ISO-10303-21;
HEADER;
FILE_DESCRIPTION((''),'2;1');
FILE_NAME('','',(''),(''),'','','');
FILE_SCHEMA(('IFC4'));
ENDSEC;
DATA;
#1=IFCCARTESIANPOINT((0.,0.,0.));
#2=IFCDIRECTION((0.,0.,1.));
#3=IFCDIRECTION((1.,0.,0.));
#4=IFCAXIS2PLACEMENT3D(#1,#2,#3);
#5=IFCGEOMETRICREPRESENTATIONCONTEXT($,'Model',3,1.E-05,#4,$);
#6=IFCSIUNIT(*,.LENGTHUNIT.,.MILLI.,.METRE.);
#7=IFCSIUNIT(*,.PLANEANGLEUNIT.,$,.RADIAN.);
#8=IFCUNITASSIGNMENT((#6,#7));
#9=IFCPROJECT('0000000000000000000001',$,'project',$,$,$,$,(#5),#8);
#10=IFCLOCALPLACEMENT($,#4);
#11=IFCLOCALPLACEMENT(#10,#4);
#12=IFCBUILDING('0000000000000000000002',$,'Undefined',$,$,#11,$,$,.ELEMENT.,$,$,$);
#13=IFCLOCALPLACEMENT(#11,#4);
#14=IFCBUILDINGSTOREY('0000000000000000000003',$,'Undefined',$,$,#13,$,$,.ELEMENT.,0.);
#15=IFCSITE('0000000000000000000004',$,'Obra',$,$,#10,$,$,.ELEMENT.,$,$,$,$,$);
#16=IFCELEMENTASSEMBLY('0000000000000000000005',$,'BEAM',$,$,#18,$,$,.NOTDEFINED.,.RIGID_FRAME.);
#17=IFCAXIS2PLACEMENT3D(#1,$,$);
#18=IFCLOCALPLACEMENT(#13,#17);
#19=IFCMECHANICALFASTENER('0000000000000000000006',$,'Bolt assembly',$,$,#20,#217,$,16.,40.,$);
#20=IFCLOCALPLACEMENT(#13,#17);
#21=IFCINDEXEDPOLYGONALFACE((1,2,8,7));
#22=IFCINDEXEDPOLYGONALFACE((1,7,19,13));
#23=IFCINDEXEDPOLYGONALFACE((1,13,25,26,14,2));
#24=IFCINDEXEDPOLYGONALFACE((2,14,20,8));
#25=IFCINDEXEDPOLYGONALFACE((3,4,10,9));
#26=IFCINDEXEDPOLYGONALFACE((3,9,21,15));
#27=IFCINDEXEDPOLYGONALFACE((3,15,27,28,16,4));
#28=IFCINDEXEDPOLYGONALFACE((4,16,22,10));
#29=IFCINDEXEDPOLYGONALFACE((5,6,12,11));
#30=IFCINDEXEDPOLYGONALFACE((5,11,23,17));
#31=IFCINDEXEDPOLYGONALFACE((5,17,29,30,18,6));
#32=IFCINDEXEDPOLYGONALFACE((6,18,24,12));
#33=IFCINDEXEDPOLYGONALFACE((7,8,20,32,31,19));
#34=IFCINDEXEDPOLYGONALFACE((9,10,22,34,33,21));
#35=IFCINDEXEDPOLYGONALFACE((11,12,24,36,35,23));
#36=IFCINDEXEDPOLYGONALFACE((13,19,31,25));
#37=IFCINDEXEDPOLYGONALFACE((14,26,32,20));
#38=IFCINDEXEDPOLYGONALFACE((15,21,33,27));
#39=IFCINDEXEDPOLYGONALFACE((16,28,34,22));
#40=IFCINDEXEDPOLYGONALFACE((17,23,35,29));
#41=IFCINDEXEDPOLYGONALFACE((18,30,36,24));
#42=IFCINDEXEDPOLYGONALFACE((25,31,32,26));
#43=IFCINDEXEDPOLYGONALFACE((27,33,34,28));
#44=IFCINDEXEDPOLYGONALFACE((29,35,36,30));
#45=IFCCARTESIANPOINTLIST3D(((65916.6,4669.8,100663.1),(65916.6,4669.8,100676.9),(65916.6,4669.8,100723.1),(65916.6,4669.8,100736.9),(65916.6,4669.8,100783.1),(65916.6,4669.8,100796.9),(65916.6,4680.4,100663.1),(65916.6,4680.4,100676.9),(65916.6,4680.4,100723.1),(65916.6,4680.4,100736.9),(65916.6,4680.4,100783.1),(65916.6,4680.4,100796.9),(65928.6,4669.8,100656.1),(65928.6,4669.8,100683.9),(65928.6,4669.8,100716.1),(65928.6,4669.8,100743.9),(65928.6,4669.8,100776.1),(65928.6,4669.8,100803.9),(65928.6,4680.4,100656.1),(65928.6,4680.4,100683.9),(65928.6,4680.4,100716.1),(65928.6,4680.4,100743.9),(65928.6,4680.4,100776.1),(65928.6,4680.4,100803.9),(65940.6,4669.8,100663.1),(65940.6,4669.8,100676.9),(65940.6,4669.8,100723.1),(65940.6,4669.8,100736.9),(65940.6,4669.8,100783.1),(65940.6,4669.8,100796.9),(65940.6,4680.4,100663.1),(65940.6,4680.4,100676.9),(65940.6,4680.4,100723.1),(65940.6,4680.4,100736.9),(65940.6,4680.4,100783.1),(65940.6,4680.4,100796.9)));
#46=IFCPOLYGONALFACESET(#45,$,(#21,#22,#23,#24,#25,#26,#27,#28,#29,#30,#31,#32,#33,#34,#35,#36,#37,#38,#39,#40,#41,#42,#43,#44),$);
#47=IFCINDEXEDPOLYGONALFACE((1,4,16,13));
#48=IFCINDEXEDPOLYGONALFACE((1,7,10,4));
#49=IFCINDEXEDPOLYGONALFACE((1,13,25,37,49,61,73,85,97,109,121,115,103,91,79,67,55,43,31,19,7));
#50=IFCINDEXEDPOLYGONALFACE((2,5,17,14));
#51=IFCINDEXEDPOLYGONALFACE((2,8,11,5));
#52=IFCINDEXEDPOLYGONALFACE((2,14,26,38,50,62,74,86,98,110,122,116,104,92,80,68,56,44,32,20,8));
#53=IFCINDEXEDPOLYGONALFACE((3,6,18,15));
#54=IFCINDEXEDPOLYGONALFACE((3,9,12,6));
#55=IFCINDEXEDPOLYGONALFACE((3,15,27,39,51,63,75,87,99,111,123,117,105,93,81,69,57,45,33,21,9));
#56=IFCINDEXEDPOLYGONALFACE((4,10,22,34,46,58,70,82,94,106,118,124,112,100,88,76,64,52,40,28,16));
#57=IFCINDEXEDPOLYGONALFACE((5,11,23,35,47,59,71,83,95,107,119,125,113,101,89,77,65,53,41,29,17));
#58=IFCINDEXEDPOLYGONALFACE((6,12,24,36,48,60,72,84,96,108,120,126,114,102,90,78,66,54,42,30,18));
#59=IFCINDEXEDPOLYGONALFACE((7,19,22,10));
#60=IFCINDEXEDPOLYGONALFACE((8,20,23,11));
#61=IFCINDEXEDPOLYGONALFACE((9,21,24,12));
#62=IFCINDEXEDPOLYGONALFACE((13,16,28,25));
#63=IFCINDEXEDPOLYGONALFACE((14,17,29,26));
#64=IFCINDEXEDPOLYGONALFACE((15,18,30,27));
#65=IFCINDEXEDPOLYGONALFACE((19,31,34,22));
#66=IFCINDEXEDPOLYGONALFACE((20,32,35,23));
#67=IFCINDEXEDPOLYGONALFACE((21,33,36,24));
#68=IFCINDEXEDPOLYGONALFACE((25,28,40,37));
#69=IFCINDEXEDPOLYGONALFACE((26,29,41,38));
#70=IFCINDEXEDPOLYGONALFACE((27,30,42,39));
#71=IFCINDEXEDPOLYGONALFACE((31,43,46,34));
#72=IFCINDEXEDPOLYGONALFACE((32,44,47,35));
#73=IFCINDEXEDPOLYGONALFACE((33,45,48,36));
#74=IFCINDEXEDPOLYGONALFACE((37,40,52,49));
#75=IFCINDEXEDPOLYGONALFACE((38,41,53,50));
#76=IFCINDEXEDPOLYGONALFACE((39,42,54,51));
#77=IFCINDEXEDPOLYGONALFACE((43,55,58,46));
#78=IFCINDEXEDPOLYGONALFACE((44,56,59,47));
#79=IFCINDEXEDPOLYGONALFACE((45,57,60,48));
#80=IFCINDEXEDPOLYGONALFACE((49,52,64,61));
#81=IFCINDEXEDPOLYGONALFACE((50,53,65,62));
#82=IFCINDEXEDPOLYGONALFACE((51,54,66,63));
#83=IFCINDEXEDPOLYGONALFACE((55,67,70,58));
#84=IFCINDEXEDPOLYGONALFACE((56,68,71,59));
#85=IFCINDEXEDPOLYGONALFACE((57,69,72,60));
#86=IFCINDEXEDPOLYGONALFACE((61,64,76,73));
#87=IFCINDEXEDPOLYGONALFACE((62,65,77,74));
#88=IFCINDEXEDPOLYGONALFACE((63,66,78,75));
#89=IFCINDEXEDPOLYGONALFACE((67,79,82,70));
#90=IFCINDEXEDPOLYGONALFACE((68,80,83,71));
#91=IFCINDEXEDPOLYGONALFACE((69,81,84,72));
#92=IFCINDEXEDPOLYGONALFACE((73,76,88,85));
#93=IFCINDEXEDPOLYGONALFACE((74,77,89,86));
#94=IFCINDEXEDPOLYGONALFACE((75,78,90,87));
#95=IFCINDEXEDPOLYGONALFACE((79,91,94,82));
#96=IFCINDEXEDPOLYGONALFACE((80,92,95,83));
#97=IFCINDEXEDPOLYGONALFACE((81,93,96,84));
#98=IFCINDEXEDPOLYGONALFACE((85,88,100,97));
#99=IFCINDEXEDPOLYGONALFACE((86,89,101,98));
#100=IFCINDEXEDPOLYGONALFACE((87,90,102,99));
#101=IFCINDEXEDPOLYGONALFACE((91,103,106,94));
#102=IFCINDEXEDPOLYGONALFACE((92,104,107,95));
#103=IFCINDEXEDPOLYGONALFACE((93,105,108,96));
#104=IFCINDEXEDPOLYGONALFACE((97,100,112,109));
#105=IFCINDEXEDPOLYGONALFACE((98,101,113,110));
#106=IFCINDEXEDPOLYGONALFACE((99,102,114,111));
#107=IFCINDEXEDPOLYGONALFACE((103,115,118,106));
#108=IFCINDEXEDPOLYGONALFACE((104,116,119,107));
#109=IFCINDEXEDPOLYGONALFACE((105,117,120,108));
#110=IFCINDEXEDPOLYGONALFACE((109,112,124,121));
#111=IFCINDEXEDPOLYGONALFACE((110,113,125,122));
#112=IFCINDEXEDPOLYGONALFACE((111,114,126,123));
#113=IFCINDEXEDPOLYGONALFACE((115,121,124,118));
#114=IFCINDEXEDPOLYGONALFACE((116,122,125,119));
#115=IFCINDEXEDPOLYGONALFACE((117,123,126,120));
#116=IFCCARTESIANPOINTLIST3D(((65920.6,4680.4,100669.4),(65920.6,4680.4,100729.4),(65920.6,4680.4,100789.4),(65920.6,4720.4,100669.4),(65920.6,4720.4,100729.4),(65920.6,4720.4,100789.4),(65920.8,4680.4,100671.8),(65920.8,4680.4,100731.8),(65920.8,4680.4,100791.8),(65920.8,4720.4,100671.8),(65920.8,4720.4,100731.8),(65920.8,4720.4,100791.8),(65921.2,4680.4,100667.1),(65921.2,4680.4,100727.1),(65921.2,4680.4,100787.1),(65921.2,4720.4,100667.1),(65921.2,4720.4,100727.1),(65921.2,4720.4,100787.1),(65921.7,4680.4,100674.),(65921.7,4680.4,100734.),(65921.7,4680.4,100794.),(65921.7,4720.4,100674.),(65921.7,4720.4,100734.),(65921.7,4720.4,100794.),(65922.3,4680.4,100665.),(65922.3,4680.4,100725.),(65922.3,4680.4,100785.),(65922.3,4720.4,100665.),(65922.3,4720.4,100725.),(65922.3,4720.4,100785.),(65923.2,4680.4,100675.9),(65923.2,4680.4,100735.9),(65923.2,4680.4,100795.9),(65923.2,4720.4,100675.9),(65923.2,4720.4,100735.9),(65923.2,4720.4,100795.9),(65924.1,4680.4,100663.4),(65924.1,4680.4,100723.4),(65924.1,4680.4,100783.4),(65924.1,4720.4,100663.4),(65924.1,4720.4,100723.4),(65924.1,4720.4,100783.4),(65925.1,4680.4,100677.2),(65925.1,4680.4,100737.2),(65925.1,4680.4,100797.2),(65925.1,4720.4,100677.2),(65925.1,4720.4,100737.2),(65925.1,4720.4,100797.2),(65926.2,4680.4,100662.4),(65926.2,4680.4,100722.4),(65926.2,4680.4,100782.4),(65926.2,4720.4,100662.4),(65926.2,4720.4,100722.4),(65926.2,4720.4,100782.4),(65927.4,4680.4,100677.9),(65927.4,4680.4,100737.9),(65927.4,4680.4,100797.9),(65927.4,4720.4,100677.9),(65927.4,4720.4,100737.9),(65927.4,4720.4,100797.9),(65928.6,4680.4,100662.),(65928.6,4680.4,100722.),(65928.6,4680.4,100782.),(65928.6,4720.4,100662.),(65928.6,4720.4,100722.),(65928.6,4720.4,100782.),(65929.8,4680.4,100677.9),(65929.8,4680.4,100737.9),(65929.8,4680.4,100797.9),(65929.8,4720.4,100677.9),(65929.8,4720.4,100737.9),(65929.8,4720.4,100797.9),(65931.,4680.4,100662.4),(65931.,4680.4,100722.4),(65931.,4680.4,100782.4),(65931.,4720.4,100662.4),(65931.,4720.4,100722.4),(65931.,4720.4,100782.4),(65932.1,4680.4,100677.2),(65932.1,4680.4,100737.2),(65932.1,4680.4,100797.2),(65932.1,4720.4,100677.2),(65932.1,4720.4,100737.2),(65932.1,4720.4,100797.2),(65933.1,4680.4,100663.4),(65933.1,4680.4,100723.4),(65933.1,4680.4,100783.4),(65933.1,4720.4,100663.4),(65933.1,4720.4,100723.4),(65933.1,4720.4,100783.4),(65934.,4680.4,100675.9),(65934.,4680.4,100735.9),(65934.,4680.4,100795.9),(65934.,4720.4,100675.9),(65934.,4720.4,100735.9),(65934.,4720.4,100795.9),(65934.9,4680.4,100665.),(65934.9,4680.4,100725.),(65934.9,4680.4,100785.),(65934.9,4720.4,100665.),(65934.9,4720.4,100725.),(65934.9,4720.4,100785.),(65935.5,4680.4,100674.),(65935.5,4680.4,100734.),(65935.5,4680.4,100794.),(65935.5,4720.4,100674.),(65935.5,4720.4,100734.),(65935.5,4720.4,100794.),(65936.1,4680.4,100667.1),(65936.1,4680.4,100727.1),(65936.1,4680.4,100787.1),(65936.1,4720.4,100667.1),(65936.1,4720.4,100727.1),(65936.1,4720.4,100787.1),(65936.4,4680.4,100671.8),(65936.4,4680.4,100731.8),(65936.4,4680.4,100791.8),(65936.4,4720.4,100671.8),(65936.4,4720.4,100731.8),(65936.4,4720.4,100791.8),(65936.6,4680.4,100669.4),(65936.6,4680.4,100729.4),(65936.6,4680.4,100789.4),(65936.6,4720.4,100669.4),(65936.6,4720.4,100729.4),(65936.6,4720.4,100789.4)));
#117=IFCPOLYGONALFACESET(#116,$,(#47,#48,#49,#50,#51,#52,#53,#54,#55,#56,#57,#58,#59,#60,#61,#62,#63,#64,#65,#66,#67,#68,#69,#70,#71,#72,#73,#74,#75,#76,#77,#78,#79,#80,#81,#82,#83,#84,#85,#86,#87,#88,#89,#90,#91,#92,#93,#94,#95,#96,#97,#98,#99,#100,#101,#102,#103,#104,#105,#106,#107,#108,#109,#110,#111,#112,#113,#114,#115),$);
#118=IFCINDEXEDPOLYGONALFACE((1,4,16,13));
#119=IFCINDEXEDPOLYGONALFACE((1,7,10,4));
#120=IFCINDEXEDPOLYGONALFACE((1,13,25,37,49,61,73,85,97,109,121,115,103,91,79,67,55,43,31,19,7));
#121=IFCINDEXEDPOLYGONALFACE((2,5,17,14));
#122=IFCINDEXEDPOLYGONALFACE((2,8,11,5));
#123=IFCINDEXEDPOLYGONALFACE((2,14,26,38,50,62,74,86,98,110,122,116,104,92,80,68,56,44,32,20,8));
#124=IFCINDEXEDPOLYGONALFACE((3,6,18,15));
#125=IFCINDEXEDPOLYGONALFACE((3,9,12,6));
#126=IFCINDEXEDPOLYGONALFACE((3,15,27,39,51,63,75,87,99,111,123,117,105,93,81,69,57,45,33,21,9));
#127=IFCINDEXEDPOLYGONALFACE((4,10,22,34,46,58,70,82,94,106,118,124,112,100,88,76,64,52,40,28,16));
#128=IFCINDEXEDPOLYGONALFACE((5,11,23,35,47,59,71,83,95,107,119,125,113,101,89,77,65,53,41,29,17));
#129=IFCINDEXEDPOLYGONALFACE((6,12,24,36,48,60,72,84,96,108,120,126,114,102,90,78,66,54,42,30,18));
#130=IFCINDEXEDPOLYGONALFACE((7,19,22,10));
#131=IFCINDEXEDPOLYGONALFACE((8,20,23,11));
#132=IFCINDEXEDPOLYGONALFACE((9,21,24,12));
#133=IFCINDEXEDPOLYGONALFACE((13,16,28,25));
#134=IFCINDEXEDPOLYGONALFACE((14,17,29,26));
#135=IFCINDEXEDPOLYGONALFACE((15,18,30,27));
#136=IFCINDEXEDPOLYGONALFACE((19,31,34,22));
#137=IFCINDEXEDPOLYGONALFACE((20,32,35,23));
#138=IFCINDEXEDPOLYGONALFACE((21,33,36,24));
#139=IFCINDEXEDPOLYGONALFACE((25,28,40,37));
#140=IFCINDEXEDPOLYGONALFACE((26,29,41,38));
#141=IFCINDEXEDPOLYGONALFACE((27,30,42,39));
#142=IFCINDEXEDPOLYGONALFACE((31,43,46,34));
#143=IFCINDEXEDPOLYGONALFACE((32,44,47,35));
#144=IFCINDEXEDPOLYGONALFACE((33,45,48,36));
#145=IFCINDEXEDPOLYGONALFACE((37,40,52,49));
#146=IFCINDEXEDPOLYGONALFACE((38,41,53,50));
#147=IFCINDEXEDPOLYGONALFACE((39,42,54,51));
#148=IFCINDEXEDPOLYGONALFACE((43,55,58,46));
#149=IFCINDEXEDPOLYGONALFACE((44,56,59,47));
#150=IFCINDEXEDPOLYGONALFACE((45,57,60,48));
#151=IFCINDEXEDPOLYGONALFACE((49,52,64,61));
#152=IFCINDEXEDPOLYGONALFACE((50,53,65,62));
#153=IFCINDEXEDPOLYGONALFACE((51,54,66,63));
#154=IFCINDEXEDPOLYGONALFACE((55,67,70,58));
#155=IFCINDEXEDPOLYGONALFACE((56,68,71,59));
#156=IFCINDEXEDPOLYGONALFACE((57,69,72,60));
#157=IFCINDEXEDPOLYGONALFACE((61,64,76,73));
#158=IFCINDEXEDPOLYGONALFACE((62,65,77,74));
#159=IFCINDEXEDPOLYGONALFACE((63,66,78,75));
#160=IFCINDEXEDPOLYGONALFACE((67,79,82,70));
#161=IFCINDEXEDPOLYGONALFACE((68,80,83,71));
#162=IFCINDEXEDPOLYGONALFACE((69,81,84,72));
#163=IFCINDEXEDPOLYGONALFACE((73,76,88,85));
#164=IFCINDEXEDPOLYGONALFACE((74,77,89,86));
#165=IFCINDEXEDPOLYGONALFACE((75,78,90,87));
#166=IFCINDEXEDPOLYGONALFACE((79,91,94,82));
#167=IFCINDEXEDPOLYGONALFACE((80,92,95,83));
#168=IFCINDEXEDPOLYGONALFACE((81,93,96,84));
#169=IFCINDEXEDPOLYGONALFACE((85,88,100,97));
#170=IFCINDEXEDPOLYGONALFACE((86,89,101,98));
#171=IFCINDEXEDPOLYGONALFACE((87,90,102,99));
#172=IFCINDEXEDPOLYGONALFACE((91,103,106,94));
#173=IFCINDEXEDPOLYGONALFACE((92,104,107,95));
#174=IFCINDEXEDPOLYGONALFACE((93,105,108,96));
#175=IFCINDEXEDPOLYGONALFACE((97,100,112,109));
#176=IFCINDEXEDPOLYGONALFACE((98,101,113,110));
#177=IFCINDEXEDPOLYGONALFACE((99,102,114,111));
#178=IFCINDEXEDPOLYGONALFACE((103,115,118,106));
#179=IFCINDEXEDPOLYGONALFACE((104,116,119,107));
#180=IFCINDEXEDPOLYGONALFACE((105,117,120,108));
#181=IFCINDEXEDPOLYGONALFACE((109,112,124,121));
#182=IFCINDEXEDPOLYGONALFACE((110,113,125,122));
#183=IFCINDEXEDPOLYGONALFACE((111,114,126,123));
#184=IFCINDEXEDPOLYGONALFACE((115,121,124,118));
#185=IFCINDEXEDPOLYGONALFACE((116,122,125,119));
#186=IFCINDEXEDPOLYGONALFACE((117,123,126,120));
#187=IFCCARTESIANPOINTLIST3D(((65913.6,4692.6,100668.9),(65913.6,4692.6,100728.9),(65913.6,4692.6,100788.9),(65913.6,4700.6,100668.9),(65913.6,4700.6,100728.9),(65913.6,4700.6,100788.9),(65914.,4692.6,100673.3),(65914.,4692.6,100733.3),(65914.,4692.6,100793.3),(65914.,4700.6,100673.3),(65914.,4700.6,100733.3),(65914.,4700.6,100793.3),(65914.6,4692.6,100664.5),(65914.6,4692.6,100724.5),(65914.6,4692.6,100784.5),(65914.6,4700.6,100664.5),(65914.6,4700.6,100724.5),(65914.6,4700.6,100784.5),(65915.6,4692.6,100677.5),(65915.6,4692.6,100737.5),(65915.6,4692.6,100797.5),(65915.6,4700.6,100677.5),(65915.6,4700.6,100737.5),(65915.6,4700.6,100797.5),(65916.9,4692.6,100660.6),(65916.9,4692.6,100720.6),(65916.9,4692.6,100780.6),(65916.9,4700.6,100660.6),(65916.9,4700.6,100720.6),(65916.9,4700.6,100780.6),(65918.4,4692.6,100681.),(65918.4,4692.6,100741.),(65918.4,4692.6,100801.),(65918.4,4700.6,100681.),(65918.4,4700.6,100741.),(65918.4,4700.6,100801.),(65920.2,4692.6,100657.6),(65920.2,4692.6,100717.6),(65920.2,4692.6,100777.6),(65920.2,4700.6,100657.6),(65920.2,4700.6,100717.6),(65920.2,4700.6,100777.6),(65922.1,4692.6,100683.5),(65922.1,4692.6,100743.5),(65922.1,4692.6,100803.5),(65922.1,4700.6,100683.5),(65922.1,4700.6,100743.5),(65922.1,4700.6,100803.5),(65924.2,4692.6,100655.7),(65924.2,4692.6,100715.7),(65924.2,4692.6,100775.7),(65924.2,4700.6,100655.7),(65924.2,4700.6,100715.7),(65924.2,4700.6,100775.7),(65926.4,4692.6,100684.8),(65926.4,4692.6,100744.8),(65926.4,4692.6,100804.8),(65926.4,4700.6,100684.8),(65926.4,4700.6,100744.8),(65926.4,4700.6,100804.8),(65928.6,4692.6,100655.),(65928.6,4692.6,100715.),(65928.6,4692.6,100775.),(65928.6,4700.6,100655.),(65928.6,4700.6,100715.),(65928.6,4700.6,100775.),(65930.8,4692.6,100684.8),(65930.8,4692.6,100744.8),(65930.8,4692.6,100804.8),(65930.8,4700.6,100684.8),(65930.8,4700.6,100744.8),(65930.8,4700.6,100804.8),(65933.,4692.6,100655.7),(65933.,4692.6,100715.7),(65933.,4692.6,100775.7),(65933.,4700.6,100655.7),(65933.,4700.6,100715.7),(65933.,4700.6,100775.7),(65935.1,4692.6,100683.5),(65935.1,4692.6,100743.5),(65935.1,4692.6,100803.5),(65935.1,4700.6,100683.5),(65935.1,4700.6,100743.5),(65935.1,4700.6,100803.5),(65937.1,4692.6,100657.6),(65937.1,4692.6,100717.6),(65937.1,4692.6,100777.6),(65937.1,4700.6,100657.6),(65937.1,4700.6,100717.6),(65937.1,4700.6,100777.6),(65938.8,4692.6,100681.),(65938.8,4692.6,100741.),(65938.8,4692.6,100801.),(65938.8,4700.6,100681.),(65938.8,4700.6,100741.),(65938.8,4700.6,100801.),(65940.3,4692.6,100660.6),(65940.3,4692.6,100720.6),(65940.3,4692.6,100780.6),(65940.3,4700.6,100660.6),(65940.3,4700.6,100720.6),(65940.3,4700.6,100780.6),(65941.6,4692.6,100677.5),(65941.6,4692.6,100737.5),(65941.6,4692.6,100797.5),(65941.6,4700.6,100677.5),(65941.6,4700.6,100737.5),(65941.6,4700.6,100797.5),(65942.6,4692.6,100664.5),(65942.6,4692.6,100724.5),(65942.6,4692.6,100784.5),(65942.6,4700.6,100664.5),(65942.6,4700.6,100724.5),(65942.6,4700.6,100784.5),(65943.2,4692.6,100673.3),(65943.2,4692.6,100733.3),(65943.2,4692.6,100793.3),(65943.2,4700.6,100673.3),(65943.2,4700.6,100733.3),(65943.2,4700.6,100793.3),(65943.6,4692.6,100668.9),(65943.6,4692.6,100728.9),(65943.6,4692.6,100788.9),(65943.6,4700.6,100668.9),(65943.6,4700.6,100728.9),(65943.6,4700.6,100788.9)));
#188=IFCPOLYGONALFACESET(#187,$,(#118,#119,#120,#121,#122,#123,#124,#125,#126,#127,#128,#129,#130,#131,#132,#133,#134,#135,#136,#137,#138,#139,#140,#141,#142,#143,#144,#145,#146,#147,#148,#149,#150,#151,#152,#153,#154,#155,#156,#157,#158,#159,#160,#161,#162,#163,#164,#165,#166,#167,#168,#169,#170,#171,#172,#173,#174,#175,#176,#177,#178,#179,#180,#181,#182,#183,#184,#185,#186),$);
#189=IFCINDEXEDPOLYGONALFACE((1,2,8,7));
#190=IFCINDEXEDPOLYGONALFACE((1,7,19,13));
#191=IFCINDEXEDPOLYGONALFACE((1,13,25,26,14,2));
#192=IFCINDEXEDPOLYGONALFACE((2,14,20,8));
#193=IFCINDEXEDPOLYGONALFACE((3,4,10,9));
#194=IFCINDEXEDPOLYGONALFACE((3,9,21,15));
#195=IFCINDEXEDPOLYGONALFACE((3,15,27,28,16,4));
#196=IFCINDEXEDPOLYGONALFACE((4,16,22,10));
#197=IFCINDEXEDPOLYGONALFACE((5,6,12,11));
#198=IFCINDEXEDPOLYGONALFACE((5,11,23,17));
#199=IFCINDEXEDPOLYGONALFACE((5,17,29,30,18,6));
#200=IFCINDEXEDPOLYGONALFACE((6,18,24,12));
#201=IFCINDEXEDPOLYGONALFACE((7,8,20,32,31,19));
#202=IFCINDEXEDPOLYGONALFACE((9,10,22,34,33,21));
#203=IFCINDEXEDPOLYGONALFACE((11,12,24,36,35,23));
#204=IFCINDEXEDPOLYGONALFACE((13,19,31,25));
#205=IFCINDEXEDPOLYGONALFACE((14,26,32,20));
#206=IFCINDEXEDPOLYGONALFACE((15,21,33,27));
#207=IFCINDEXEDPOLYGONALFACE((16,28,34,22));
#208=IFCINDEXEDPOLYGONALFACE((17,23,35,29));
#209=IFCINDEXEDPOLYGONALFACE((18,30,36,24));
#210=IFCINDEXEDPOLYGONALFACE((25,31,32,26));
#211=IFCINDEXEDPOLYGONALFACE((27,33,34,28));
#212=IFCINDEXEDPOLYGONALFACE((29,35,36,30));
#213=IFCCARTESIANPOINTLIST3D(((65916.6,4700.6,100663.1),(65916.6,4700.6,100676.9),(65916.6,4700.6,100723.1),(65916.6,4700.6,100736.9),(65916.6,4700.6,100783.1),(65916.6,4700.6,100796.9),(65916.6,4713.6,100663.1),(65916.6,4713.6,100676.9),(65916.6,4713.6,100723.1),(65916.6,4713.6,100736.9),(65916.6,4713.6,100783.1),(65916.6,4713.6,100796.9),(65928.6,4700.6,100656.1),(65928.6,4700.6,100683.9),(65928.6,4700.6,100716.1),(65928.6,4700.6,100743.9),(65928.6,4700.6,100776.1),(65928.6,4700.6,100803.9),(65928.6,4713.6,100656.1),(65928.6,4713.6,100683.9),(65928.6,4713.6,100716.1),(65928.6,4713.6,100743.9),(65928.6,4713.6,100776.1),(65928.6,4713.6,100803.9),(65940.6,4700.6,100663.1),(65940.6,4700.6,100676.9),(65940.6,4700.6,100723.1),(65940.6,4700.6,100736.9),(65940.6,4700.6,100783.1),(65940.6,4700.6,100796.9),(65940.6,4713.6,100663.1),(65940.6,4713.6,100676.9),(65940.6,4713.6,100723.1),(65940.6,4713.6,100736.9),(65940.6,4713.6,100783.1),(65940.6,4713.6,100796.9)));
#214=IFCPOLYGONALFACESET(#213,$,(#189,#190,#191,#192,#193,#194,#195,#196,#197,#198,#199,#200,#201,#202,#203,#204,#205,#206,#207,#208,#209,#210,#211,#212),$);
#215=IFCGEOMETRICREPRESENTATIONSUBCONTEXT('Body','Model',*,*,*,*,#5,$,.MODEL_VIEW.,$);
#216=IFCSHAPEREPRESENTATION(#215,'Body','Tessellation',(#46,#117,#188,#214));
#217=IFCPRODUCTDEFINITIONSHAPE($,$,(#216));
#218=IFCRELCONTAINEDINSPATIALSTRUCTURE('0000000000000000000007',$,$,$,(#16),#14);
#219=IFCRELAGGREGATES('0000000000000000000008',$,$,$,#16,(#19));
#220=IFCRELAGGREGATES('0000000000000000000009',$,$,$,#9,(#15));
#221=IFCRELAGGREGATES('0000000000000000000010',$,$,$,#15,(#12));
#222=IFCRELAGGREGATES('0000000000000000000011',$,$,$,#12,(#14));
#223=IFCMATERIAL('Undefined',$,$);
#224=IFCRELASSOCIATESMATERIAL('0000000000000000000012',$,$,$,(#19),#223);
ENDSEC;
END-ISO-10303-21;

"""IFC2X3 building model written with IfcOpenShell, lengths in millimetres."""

from ifc_helpers import new_model, si_unit, frame, origin_with_axes, origin_2d_with_axis, place, context, subcontext, project, spatial, polyline, circle, outline, extrude, source, transform, mapped, material, element, aggregate, save


model = new_model("IFC2X3")

# Units and contexts
model_context = context("Model", 3, precision=1e-05, world=origin_with_axes())
body_context = subcontext(model_context, "Body", "Model", "MODEL_VIEW")
ifc_project = project(units=[si_unit("LENGTHUNIT", "METRE", prefix="MILLI"), si_unit("PLANEANGLEUNIT", "RADIAN")], contexts=[model_context])

# Site, building, storey
site_placement = place(None, origin_with_axes())
site = spatial("IfcSite", under=ifc_project, at=site_placement, Name="Obra", CompositionType="ELEMENT")
building_placement = place(site_placement, origin_with_axes())
building = spatial("IfcBuilding", under=site, at=building_placement, Name="Undefined", CompositionType="ELEMENT")
storey_placement = place(building_placement, origin_with_axes())
storey = spatial("IfcBuildingStorey", under=building, at=storey_placement, Name="Undefined", CompositionType="ELEMENT", Elevation=0.0)

# Shared definitions
ifc_material_1 = material(Name="Undefined")

# Element assembly
assembly_1_placement = place(storey_placement, origin_with_axes())
assembly_1 = element("IfcElementAssembly", 1, at=assembly_1_placement, inside=storey, Name="BEAM", AssemblyPlace="NOTDEFINED", PredefinedType="RIGID_FRAME")
shared_shape_1 = source(origin_with_axes(), body_context, "Body", "SweptSolid", [
    extrude(outline(polyline([(13.9, 0.0), (6.9, 12.0), (-6.9, 12.0), (-13.9, 0.0), (-6.9, -12.0), (6.9, -12.0), (13.9, 0.0)])), frame((0.0, -19.7, 0.0), z_axis=(0.0, 1.0, 0.0), x_axis=(1.0, 0.0, 0.0)), (0.0, 0.0, 1.0), 10.6),
    extrude(circle(Radius=8.0, at=origin_2d_with_axis()), frame((0.0, -9.1, 0.0), z_axis=(0.0, 1.0, 0.0), x_axis=(1.0, 0.0, 0.0)), (0.0, 0.0, 1.0), 40.0),
    extrude(circle(Radius=15.0, at=origin_2d_with_axis()), frame((0.0, 3.1, 0.0), z_axis=(0.0, 1.0, 0.0), x_axis=(1.0, 0.0, 0.0)), (0.0, 0.0, 1.0), 8.0),
    extrude(outline(polyline([(13.9, 0.0), (6.9, 12.0), (-6.9, 12.0), (-13.9, 0.0), (-6.9, -12.0), (6.9, -12.0), (13.9, 0.0)])), frame((0.0, 11.1, 0.0), z_axis=(0.0, 1.0, 0.0), x_axis=(1.0, 0.0, 0.0)), (0.0, 0.0, 1.0), 13.0),
])

# Mechanical fastener
mechanical_fastener_1_placement = place(assembly_1_placement, frame((65878.6, 4689.5, 100850.0), z_axis=(1.0, 0.0, 0.0), x_axis=(0.0, 0.0, -1.0)))
mechanical_fastener_1 = element("IfcMechanicalFastener", 2, at=mechanical_fastener_1_placement, material=ifc_material_1, Name="Bolt assembly", NominalDiameter=16.0, NominalLength=40.0, context=body_context, shape_type="MappedRepresentation", body=[
    mapped(shared_shape_1, transform((60.0, 0.0, 50.0))),
    mapped(shared_shape_1, transform((120.0, 0.0, 50.0))),
    mapped(shared_shape_1, transform((180.0, 0.0, 50.0))),
])
aggregate(assembly_1, [mechanical_fastener_1])

save(model, "model.ifc")
